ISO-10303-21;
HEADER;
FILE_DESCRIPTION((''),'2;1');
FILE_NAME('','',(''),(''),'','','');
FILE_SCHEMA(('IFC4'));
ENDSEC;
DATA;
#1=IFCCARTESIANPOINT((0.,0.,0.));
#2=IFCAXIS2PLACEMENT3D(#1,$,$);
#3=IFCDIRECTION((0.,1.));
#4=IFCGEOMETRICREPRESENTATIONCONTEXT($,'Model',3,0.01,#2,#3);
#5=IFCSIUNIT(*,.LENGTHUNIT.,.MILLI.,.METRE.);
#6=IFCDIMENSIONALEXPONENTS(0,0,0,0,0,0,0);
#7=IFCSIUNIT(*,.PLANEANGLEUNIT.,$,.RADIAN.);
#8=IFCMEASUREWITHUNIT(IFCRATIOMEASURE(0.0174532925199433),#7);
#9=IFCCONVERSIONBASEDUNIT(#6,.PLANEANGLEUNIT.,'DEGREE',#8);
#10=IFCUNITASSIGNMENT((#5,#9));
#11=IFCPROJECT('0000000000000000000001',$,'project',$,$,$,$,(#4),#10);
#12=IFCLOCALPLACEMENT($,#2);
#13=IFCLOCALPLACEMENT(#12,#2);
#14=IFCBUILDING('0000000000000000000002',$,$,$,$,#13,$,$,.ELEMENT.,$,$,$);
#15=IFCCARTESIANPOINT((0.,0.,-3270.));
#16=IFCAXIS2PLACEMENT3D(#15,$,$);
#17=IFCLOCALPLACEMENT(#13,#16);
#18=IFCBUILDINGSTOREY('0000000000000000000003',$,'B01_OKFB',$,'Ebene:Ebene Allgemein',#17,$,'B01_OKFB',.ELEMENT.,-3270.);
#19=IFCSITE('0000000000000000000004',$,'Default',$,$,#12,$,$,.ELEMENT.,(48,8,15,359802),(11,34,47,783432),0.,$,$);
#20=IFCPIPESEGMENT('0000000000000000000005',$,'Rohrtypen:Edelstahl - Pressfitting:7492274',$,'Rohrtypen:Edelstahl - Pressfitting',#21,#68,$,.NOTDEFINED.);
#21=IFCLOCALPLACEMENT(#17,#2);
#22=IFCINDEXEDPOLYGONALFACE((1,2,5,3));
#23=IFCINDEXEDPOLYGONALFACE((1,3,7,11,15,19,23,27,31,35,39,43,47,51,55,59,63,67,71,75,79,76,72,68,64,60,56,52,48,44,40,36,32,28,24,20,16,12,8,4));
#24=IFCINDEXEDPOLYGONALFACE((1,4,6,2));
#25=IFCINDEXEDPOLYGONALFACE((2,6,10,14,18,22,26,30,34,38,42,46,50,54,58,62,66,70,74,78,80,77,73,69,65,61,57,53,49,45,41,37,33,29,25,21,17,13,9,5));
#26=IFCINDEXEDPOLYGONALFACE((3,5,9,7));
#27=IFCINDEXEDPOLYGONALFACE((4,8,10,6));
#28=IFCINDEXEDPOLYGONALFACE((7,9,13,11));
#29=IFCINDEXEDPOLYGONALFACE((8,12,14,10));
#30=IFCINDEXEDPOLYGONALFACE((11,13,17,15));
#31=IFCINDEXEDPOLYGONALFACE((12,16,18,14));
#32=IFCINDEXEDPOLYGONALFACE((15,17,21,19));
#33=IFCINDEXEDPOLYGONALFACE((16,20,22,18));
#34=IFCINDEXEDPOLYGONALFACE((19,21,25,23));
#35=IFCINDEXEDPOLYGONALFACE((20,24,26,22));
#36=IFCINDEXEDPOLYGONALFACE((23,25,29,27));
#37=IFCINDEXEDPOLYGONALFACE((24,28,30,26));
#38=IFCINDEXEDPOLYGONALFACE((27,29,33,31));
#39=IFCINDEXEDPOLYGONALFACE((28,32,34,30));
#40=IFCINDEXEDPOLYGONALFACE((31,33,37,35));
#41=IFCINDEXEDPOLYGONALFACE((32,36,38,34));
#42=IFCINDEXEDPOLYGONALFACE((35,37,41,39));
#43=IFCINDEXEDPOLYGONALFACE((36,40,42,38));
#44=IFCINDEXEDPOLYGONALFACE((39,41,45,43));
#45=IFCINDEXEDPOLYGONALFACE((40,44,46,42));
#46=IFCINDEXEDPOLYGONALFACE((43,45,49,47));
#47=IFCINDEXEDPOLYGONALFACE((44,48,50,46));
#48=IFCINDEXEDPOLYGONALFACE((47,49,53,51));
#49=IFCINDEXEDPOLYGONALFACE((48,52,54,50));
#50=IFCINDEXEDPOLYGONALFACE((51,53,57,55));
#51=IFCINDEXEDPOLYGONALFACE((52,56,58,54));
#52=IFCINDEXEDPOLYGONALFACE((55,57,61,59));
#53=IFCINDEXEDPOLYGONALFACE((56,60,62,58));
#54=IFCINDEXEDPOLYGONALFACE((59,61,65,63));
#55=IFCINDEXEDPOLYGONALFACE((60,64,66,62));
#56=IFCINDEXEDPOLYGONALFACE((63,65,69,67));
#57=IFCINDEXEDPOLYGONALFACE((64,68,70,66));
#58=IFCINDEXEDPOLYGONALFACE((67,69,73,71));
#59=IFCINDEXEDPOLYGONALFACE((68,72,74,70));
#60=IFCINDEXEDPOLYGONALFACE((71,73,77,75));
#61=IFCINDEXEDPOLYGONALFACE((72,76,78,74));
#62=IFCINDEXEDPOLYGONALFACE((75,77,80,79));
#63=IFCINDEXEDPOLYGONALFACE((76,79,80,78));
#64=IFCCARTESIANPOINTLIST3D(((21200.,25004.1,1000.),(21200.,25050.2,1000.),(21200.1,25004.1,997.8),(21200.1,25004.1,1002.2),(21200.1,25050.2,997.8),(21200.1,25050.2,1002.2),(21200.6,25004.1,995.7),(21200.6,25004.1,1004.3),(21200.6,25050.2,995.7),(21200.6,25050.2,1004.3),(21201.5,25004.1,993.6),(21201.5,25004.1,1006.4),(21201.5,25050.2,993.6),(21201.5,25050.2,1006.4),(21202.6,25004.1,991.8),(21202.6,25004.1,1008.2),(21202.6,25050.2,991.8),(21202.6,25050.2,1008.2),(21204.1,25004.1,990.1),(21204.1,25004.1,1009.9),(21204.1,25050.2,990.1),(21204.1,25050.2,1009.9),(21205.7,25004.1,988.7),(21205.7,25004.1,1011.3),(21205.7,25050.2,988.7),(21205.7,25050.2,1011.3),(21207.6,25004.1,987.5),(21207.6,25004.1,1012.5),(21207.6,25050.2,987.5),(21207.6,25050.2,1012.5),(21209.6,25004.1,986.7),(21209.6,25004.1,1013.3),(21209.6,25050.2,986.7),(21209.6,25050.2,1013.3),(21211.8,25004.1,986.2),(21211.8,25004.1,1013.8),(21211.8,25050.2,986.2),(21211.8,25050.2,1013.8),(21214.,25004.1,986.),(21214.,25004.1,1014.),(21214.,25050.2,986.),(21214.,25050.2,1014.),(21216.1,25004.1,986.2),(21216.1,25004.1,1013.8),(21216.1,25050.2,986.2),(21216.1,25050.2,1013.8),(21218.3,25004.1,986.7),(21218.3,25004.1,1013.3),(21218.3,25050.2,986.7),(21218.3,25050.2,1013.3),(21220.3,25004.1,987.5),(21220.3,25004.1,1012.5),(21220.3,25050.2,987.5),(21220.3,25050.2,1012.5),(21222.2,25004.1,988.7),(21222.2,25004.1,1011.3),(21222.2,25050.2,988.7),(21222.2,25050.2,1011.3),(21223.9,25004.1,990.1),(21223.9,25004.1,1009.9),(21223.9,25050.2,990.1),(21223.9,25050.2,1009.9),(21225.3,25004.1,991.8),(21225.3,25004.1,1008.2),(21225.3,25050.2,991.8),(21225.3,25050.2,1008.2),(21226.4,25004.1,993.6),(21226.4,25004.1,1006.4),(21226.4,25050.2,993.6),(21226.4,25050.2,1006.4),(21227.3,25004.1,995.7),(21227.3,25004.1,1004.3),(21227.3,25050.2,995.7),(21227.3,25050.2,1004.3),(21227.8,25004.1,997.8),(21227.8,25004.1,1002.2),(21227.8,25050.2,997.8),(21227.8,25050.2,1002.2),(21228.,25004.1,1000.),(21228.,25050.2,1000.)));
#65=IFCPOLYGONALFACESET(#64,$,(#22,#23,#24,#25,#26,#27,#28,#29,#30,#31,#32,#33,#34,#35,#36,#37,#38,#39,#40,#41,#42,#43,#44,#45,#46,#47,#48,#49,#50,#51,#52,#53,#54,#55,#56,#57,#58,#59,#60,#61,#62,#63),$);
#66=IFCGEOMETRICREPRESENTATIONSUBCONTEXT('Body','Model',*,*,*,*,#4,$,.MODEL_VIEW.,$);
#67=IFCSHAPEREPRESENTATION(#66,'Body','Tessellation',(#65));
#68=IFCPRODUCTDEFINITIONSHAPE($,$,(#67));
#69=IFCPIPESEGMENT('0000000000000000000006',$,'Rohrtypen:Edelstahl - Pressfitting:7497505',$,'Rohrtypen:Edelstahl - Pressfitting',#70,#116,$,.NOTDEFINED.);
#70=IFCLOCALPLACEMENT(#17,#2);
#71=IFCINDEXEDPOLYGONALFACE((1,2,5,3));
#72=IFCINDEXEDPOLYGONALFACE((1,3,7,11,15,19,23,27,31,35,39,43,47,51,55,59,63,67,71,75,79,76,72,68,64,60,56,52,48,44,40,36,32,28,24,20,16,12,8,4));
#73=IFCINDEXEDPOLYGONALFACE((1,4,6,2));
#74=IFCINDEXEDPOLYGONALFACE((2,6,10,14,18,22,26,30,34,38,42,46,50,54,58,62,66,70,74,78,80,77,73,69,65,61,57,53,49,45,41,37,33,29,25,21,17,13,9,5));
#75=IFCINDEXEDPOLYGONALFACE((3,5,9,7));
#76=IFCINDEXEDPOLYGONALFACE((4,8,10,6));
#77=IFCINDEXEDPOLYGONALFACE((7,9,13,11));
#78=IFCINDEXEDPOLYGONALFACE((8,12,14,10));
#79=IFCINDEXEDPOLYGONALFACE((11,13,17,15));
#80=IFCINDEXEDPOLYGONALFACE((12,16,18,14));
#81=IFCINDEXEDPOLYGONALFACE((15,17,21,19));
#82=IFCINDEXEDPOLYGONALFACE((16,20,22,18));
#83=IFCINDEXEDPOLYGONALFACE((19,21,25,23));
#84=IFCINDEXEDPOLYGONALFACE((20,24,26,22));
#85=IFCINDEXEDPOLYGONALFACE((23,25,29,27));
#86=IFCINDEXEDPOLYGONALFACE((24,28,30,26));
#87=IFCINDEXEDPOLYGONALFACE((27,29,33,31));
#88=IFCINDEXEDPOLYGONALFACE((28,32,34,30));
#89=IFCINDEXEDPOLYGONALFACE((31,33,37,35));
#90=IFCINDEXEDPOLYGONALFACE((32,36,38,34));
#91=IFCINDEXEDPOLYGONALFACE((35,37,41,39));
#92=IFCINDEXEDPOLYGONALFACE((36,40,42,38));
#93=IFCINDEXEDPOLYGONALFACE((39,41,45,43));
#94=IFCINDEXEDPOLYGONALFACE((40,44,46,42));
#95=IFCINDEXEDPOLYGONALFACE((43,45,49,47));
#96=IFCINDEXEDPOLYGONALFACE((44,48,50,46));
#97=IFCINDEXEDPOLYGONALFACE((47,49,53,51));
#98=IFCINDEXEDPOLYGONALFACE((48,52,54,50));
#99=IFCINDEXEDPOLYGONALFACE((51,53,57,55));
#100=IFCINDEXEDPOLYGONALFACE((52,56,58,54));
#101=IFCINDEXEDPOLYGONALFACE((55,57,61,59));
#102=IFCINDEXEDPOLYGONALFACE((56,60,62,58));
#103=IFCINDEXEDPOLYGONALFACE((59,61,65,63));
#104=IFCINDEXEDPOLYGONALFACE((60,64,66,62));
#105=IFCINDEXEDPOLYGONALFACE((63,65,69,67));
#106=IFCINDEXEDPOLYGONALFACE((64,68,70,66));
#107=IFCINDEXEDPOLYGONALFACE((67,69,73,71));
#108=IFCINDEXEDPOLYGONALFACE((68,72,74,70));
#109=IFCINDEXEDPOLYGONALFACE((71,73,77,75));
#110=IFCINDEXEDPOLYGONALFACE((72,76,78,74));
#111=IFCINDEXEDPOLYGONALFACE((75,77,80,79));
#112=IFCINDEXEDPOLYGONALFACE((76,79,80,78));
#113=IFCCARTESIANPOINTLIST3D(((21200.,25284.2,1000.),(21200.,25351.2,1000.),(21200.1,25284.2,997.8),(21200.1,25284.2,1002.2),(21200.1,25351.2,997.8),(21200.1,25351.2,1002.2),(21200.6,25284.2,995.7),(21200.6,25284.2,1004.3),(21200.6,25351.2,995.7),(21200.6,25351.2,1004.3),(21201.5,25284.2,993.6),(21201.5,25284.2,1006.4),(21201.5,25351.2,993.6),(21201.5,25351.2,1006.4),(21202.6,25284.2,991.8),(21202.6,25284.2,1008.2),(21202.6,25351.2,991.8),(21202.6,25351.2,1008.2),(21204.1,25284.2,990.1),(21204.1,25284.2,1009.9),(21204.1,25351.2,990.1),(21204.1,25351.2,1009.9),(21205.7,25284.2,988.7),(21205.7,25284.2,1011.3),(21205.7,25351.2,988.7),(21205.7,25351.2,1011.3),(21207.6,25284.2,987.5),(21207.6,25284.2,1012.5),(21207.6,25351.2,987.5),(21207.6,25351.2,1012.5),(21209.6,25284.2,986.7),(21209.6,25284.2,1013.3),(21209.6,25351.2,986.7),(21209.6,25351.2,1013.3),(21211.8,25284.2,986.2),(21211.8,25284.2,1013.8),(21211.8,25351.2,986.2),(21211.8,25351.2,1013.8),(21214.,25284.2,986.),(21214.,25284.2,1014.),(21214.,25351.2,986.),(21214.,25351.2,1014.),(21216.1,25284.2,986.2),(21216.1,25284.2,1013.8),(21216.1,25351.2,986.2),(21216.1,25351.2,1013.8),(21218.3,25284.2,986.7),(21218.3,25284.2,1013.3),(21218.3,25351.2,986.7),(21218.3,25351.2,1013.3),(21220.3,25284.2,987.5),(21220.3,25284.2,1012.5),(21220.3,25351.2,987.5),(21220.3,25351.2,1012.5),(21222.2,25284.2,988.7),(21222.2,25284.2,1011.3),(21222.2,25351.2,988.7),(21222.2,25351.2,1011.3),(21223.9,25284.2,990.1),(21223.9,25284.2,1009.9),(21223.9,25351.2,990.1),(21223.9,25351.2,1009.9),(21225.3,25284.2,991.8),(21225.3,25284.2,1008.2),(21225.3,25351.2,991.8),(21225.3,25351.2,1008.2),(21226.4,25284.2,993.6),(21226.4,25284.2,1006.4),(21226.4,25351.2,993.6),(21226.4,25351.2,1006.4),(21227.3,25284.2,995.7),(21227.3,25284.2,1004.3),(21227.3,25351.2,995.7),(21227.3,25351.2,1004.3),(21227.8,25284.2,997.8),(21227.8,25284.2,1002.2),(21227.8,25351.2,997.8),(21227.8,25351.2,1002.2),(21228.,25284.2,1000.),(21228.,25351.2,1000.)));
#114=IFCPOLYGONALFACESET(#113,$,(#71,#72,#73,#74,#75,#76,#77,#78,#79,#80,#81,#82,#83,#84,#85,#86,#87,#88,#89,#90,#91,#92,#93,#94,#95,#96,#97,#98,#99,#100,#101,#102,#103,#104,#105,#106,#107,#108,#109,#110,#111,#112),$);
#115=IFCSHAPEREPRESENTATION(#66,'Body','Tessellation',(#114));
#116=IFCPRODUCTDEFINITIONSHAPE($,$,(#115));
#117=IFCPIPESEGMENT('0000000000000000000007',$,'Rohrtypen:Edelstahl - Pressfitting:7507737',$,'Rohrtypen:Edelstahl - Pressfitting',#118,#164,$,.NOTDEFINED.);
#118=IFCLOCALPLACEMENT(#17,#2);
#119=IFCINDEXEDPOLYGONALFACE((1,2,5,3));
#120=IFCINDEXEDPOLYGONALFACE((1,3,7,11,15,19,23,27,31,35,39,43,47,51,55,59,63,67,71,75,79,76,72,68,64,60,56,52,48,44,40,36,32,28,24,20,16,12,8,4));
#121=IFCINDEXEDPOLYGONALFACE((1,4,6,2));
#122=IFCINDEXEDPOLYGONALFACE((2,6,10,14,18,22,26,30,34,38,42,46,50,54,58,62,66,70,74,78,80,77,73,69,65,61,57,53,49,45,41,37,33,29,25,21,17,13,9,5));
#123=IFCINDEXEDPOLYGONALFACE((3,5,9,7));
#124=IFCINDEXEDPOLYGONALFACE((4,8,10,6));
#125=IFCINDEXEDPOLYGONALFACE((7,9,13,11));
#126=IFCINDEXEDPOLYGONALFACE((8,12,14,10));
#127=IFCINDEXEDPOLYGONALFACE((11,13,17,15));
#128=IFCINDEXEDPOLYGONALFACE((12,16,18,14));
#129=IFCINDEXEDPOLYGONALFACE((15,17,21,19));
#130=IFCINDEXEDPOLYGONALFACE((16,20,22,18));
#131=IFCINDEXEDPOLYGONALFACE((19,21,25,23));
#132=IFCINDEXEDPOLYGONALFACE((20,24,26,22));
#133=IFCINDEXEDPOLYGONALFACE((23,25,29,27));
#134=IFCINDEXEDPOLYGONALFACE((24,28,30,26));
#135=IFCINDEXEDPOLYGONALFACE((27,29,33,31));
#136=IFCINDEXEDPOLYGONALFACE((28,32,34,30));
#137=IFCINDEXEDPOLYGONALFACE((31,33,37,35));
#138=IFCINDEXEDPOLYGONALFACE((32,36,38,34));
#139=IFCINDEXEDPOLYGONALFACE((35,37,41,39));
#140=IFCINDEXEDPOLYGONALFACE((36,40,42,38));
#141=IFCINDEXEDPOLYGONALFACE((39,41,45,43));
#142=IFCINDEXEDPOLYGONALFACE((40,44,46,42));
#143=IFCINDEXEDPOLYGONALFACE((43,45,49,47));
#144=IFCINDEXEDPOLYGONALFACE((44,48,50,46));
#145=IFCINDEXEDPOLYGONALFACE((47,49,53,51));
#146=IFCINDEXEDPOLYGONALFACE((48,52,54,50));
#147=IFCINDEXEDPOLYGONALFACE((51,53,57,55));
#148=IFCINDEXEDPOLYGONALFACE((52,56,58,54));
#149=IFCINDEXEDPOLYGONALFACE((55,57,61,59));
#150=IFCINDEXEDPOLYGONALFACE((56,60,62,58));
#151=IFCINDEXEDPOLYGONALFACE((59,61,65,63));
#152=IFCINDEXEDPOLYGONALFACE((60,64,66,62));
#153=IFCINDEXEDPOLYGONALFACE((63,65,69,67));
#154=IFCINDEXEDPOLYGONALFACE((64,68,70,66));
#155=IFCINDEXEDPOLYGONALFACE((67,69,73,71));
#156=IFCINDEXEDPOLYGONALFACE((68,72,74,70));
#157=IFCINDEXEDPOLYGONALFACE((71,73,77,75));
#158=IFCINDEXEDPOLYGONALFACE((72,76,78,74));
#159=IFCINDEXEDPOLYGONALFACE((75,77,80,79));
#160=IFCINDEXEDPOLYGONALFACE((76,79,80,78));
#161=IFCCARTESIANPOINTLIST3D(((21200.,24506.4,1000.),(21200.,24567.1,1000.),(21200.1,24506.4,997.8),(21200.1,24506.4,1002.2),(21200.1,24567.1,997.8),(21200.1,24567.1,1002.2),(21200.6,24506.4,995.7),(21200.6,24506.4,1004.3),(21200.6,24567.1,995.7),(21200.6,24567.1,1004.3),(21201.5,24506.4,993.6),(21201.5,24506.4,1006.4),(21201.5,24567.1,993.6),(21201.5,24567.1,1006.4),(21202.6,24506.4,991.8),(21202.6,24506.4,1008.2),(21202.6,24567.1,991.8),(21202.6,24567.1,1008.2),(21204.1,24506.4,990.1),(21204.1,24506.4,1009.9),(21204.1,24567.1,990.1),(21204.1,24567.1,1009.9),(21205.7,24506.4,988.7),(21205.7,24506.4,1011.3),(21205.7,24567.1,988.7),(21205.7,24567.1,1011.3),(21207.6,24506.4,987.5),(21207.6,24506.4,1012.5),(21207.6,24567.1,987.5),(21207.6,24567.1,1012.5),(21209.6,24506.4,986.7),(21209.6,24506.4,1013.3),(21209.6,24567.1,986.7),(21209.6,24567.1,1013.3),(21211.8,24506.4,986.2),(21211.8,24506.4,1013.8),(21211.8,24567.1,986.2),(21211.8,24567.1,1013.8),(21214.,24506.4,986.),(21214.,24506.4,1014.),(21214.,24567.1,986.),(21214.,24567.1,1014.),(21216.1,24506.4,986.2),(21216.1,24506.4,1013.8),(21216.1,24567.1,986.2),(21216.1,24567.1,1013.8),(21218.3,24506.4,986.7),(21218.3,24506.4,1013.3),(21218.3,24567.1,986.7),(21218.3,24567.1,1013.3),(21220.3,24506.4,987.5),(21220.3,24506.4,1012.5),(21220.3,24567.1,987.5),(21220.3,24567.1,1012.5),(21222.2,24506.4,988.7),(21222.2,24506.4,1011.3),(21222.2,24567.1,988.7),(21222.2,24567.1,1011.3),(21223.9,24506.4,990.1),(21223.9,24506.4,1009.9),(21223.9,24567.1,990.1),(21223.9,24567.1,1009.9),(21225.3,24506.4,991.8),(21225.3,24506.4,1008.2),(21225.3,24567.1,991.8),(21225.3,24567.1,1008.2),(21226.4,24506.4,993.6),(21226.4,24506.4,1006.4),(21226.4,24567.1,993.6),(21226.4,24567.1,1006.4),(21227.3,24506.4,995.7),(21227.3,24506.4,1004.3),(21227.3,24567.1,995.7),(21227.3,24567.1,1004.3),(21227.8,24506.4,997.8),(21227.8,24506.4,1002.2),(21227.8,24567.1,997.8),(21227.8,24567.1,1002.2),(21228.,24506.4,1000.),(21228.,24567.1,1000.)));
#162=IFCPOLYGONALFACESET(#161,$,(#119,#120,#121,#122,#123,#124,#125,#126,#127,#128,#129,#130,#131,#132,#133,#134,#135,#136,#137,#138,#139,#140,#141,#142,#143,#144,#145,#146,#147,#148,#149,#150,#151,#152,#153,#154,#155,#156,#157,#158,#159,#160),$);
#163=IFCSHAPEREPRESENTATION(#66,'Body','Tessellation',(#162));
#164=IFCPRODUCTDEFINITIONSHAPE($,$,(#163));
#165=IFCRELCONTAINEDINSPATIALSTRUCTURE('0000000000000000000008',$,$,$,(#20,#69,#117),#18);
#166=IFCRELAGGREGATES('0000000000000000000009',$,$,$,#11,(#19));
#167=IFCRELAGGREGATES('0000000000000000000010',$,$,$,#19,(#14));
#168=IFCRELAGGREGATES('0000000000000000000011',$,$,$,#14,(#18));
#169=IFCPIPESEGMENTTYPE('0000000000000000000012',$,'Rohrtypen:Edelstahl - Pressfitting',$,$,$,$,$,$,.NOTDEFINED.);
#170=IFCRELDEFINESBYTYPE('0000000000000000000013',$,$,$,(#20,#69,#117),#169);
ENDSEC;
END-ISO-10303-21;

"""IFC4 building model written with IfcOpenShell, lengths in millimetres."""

from ifc_helpers import new_model, entity, si_unit, converted_unit, direction, frame, origin, place, context, subcontext, project, spatial, indexed_curve, outline, extrude, type_object, element, save


model = new_model("IFC4")

# Units and contexts
model_context = context("Model", 3, precision=0.01, world=origin(), true_north=direction((0.0, 1.0)))
body_context = subcontext(model_context, "Body", "Model", "MODEL_VIEW")
ifc_project = project(units=[si_unit("LENGTHUNIT", "METRE", prefix="MILLI"), converted_unit("PLANEANGLEUNIT", "DEGREE", entity("IfcRatioMeasure", 0.0174532925199433), si_unit("PLANEANGLEUNIT", "RADIAN"), dimensions=[0, 0, 0, 0, 0, 0, 0])], contexts=[model_context])

# Site, building, storey
site_placement = place(None, origin())
site = spatial("IfcSite", under=ifc_project, at=site_placement, Name="Default", CompositionType="ELEMENT", RefLatitude=(48, 8, 15, 359802), RefLongitude=(11, 34, 47, 783432), RefElevation=0.0)
building_placement = place(site_placement, origin())
building = spatial("IfcBuilding", under=site, at=building_placement, CompositionType="ELEMENT")
storey_placement = place(building_placement, frame((0.0, 0.0, -3270.0)))
storey = spatial("IfcBuildingStorey", under=building, at=storey_placement, Name="B01_OKFB", ObjectType="Ebene:Ebene Allgemein", LongName="B01_OKFB", CompositionType="ELEMENT", Elevation=-3270.0)

# Pipe segments
pipe_segment_type_1 = type_object("IfcPipeSegmentType", Name="Rohrtypen:Edelstahl - Pressfitting", PredefinedType="NOTDEFINED")
pipe_segment_1_placement = place(storey_placement, origin())
element("IfcPipeSegment", 1, at=pipe_segment_1_placement, inside=storey, type_object=pipe_segment_type_1, Name="Rohrtypen:Edelstahl - Pressfitting:7492274", ObjectType="Rohrtypen:Edelstahl - Pressfitting", PredefinedType="NOTDEFINED", context=body_context, shape_type="SweptSolid", body=[
    extrude(outline(indexed_curve([(14.0, 0.0), (13.8, 2.2), (13.3, 4.3), (12.5, 6.4), (11.3, 8.2), (9.9, 9.9), (8.2, 11.3), (6.4, 12.5), (4.3, 13.3), (2.2, 13.8), (0.0, 14.0), (-2.2, 13.8), (-4.3, 13.3), (-6.4, 12.5), (-8.2, 11.3), (-9.9, 9.9), (-11.3, 8.2), (-12.5, 6.4), (-13.3, 4.3), (-13.8, 2.2), (-14.0, 0.0), (-13.8, -2.2), (-13.3, -4.3), (-12.5, -6.4), (-11.3, -8.2), (-9.9, -9.9), (-8.2, -11.3), (-6.4, -12.5), (-4.3, -13.3), (-2.2, -13.8), (0.0, -14.0), (2.2, -13.8), (4.3, -13.3), (6.4, -12.5), (8.2, -11.3), (9.9, -9.9), (11.3, -8.2), (12.5, -6.4), (13.3, -4.3), (13.8, -2.2), (14.0, 0.0)], self_intersect=False)), frame((21214.0, 25004.1, 1000.0), z_axis=(0.0, 1.0, 0.0), x_axis=(1.0, 0.0, 0.0)), (0.0, 0.0, 1.0), 46.1),
])
pipe_segment_2_placement = place(storey_placement, origin())
element("IfcPipeSegment", 2, at=pipe_segment_2_placement, inside=storey, type_object=pipe_segment_type_1, Name="Rohrtypen:Edelstahl - Pressfitting:7497505", ObjectType="Rohrtypen:Edelstahl - Pressfitting", PredefinedType="NOTDEFINED", context=body_context, shape_type="SweptSolid", body=[
    extrude(outline(indexed_curve([(14.0, 0.0), (13.8, 2.2), (13.3, 4.3), (12.5, 6.4), (11.3, 8.2), (9.9, 9.9), (8.2, 11.3), (6.4, 12.5), (4.3, 13.3), (2.2, 13.8), (0.0, 14.0), (-2.2, 13.8), (-4.3, 13.3), (-6.4, 12.5), (-8.2, 11.3), (-9.9, 9.9), (-11.3, 8.2), (-12.5, 6.4), (-13.3, 4.3), (-13.8, 2.2), (-14.0, 0.0), (-13.8, -2.2), (-13.3, -4.3), (-12.5, -6.4), (-11.3, -8.2), (-9.9, -9.9), (-8.2, -11.3), (-6.4, -12.5), (-4.3, -13.3), (-2.2, -13.8), (0.0, -14.0), (2.2, -13.8), (4.3, -13.3), (6.4, -12.5), (8.2, -11.3), (9.9, -9.9), (11.3, -8.2), (12.5, -6.4), (13.3, -4.3), (13.8, -2.2), (14.0, 0.0)], self_intersect=False)), frame((21214.0, 25284.2, 1000.0), z_axis=(0.0, 1.0, 0.0), x_axis=(1.0, 0.0, 0.0)), (0.0, 0.0, 1.0), 66.9),
])
pipe_segment_3_placement = place(storey_placement, origin())
element("IfcPipeSegment", 3, at=pipe_segment_3_placement, inside=storey, type_object=pipe_segment_type_1, Name="Rohrtypen:Edelstahl - Pressfitting:7507737", ObjectType="Rohrtypen:Edelstahl - Pressfitting", PredefinedType="NOTDEFINED", context=body_context, shape_type="SweptSolid", body=[
    extrude(outline(indexed_curve([(14.0, 0.0), (13.8, 2.2), (13.3, 4.3), (12.5, 6.4), (11.3, 8.2), (9.9, 9.9), (8.2, 11.3), (6.4, 12.5), (4.3, 13.3), (2.2, 13.8), (0.0, 14.0), (-2.2, 13.8), (-4.3, 13.3), (-6.4, 12.5), (-8.2, 11.3), (-9.9, 9.9), (-11.3, 8.2), (-12.5, 6.4), (-13.3, 4.3), (-13.8, 2.2), (-14.0, 0.0), (-13.8, -2.2), (-13.3, -4.3), (-12.5, -6.4), (-11.3, -8.2), (-9.9, -9.9), (-8.2, -11.3), (-6.4, -12.5), (-4.3, -13.3), (-2.2, -13.8), (0.0, -14.0), (2.2, -13.8), (4.3, -13.3), (6.4, -12.5), (8.2, -11.3), (9.9, -9.9), (11.3, -8.2), (12.5, -6.4), (13.3, -4.3), (13.8, -2.2), (14.0, 0.0)], self_intersect=False)), frame((21214.0, 24506.4, 1000.0), z_axis=(0.0, 1.0, 0.0), x_axis=(1.0, 0.0, 0.0)), (0.0, 0.0, 1.0), 60.7),
])

save(model, "model.ifc")
